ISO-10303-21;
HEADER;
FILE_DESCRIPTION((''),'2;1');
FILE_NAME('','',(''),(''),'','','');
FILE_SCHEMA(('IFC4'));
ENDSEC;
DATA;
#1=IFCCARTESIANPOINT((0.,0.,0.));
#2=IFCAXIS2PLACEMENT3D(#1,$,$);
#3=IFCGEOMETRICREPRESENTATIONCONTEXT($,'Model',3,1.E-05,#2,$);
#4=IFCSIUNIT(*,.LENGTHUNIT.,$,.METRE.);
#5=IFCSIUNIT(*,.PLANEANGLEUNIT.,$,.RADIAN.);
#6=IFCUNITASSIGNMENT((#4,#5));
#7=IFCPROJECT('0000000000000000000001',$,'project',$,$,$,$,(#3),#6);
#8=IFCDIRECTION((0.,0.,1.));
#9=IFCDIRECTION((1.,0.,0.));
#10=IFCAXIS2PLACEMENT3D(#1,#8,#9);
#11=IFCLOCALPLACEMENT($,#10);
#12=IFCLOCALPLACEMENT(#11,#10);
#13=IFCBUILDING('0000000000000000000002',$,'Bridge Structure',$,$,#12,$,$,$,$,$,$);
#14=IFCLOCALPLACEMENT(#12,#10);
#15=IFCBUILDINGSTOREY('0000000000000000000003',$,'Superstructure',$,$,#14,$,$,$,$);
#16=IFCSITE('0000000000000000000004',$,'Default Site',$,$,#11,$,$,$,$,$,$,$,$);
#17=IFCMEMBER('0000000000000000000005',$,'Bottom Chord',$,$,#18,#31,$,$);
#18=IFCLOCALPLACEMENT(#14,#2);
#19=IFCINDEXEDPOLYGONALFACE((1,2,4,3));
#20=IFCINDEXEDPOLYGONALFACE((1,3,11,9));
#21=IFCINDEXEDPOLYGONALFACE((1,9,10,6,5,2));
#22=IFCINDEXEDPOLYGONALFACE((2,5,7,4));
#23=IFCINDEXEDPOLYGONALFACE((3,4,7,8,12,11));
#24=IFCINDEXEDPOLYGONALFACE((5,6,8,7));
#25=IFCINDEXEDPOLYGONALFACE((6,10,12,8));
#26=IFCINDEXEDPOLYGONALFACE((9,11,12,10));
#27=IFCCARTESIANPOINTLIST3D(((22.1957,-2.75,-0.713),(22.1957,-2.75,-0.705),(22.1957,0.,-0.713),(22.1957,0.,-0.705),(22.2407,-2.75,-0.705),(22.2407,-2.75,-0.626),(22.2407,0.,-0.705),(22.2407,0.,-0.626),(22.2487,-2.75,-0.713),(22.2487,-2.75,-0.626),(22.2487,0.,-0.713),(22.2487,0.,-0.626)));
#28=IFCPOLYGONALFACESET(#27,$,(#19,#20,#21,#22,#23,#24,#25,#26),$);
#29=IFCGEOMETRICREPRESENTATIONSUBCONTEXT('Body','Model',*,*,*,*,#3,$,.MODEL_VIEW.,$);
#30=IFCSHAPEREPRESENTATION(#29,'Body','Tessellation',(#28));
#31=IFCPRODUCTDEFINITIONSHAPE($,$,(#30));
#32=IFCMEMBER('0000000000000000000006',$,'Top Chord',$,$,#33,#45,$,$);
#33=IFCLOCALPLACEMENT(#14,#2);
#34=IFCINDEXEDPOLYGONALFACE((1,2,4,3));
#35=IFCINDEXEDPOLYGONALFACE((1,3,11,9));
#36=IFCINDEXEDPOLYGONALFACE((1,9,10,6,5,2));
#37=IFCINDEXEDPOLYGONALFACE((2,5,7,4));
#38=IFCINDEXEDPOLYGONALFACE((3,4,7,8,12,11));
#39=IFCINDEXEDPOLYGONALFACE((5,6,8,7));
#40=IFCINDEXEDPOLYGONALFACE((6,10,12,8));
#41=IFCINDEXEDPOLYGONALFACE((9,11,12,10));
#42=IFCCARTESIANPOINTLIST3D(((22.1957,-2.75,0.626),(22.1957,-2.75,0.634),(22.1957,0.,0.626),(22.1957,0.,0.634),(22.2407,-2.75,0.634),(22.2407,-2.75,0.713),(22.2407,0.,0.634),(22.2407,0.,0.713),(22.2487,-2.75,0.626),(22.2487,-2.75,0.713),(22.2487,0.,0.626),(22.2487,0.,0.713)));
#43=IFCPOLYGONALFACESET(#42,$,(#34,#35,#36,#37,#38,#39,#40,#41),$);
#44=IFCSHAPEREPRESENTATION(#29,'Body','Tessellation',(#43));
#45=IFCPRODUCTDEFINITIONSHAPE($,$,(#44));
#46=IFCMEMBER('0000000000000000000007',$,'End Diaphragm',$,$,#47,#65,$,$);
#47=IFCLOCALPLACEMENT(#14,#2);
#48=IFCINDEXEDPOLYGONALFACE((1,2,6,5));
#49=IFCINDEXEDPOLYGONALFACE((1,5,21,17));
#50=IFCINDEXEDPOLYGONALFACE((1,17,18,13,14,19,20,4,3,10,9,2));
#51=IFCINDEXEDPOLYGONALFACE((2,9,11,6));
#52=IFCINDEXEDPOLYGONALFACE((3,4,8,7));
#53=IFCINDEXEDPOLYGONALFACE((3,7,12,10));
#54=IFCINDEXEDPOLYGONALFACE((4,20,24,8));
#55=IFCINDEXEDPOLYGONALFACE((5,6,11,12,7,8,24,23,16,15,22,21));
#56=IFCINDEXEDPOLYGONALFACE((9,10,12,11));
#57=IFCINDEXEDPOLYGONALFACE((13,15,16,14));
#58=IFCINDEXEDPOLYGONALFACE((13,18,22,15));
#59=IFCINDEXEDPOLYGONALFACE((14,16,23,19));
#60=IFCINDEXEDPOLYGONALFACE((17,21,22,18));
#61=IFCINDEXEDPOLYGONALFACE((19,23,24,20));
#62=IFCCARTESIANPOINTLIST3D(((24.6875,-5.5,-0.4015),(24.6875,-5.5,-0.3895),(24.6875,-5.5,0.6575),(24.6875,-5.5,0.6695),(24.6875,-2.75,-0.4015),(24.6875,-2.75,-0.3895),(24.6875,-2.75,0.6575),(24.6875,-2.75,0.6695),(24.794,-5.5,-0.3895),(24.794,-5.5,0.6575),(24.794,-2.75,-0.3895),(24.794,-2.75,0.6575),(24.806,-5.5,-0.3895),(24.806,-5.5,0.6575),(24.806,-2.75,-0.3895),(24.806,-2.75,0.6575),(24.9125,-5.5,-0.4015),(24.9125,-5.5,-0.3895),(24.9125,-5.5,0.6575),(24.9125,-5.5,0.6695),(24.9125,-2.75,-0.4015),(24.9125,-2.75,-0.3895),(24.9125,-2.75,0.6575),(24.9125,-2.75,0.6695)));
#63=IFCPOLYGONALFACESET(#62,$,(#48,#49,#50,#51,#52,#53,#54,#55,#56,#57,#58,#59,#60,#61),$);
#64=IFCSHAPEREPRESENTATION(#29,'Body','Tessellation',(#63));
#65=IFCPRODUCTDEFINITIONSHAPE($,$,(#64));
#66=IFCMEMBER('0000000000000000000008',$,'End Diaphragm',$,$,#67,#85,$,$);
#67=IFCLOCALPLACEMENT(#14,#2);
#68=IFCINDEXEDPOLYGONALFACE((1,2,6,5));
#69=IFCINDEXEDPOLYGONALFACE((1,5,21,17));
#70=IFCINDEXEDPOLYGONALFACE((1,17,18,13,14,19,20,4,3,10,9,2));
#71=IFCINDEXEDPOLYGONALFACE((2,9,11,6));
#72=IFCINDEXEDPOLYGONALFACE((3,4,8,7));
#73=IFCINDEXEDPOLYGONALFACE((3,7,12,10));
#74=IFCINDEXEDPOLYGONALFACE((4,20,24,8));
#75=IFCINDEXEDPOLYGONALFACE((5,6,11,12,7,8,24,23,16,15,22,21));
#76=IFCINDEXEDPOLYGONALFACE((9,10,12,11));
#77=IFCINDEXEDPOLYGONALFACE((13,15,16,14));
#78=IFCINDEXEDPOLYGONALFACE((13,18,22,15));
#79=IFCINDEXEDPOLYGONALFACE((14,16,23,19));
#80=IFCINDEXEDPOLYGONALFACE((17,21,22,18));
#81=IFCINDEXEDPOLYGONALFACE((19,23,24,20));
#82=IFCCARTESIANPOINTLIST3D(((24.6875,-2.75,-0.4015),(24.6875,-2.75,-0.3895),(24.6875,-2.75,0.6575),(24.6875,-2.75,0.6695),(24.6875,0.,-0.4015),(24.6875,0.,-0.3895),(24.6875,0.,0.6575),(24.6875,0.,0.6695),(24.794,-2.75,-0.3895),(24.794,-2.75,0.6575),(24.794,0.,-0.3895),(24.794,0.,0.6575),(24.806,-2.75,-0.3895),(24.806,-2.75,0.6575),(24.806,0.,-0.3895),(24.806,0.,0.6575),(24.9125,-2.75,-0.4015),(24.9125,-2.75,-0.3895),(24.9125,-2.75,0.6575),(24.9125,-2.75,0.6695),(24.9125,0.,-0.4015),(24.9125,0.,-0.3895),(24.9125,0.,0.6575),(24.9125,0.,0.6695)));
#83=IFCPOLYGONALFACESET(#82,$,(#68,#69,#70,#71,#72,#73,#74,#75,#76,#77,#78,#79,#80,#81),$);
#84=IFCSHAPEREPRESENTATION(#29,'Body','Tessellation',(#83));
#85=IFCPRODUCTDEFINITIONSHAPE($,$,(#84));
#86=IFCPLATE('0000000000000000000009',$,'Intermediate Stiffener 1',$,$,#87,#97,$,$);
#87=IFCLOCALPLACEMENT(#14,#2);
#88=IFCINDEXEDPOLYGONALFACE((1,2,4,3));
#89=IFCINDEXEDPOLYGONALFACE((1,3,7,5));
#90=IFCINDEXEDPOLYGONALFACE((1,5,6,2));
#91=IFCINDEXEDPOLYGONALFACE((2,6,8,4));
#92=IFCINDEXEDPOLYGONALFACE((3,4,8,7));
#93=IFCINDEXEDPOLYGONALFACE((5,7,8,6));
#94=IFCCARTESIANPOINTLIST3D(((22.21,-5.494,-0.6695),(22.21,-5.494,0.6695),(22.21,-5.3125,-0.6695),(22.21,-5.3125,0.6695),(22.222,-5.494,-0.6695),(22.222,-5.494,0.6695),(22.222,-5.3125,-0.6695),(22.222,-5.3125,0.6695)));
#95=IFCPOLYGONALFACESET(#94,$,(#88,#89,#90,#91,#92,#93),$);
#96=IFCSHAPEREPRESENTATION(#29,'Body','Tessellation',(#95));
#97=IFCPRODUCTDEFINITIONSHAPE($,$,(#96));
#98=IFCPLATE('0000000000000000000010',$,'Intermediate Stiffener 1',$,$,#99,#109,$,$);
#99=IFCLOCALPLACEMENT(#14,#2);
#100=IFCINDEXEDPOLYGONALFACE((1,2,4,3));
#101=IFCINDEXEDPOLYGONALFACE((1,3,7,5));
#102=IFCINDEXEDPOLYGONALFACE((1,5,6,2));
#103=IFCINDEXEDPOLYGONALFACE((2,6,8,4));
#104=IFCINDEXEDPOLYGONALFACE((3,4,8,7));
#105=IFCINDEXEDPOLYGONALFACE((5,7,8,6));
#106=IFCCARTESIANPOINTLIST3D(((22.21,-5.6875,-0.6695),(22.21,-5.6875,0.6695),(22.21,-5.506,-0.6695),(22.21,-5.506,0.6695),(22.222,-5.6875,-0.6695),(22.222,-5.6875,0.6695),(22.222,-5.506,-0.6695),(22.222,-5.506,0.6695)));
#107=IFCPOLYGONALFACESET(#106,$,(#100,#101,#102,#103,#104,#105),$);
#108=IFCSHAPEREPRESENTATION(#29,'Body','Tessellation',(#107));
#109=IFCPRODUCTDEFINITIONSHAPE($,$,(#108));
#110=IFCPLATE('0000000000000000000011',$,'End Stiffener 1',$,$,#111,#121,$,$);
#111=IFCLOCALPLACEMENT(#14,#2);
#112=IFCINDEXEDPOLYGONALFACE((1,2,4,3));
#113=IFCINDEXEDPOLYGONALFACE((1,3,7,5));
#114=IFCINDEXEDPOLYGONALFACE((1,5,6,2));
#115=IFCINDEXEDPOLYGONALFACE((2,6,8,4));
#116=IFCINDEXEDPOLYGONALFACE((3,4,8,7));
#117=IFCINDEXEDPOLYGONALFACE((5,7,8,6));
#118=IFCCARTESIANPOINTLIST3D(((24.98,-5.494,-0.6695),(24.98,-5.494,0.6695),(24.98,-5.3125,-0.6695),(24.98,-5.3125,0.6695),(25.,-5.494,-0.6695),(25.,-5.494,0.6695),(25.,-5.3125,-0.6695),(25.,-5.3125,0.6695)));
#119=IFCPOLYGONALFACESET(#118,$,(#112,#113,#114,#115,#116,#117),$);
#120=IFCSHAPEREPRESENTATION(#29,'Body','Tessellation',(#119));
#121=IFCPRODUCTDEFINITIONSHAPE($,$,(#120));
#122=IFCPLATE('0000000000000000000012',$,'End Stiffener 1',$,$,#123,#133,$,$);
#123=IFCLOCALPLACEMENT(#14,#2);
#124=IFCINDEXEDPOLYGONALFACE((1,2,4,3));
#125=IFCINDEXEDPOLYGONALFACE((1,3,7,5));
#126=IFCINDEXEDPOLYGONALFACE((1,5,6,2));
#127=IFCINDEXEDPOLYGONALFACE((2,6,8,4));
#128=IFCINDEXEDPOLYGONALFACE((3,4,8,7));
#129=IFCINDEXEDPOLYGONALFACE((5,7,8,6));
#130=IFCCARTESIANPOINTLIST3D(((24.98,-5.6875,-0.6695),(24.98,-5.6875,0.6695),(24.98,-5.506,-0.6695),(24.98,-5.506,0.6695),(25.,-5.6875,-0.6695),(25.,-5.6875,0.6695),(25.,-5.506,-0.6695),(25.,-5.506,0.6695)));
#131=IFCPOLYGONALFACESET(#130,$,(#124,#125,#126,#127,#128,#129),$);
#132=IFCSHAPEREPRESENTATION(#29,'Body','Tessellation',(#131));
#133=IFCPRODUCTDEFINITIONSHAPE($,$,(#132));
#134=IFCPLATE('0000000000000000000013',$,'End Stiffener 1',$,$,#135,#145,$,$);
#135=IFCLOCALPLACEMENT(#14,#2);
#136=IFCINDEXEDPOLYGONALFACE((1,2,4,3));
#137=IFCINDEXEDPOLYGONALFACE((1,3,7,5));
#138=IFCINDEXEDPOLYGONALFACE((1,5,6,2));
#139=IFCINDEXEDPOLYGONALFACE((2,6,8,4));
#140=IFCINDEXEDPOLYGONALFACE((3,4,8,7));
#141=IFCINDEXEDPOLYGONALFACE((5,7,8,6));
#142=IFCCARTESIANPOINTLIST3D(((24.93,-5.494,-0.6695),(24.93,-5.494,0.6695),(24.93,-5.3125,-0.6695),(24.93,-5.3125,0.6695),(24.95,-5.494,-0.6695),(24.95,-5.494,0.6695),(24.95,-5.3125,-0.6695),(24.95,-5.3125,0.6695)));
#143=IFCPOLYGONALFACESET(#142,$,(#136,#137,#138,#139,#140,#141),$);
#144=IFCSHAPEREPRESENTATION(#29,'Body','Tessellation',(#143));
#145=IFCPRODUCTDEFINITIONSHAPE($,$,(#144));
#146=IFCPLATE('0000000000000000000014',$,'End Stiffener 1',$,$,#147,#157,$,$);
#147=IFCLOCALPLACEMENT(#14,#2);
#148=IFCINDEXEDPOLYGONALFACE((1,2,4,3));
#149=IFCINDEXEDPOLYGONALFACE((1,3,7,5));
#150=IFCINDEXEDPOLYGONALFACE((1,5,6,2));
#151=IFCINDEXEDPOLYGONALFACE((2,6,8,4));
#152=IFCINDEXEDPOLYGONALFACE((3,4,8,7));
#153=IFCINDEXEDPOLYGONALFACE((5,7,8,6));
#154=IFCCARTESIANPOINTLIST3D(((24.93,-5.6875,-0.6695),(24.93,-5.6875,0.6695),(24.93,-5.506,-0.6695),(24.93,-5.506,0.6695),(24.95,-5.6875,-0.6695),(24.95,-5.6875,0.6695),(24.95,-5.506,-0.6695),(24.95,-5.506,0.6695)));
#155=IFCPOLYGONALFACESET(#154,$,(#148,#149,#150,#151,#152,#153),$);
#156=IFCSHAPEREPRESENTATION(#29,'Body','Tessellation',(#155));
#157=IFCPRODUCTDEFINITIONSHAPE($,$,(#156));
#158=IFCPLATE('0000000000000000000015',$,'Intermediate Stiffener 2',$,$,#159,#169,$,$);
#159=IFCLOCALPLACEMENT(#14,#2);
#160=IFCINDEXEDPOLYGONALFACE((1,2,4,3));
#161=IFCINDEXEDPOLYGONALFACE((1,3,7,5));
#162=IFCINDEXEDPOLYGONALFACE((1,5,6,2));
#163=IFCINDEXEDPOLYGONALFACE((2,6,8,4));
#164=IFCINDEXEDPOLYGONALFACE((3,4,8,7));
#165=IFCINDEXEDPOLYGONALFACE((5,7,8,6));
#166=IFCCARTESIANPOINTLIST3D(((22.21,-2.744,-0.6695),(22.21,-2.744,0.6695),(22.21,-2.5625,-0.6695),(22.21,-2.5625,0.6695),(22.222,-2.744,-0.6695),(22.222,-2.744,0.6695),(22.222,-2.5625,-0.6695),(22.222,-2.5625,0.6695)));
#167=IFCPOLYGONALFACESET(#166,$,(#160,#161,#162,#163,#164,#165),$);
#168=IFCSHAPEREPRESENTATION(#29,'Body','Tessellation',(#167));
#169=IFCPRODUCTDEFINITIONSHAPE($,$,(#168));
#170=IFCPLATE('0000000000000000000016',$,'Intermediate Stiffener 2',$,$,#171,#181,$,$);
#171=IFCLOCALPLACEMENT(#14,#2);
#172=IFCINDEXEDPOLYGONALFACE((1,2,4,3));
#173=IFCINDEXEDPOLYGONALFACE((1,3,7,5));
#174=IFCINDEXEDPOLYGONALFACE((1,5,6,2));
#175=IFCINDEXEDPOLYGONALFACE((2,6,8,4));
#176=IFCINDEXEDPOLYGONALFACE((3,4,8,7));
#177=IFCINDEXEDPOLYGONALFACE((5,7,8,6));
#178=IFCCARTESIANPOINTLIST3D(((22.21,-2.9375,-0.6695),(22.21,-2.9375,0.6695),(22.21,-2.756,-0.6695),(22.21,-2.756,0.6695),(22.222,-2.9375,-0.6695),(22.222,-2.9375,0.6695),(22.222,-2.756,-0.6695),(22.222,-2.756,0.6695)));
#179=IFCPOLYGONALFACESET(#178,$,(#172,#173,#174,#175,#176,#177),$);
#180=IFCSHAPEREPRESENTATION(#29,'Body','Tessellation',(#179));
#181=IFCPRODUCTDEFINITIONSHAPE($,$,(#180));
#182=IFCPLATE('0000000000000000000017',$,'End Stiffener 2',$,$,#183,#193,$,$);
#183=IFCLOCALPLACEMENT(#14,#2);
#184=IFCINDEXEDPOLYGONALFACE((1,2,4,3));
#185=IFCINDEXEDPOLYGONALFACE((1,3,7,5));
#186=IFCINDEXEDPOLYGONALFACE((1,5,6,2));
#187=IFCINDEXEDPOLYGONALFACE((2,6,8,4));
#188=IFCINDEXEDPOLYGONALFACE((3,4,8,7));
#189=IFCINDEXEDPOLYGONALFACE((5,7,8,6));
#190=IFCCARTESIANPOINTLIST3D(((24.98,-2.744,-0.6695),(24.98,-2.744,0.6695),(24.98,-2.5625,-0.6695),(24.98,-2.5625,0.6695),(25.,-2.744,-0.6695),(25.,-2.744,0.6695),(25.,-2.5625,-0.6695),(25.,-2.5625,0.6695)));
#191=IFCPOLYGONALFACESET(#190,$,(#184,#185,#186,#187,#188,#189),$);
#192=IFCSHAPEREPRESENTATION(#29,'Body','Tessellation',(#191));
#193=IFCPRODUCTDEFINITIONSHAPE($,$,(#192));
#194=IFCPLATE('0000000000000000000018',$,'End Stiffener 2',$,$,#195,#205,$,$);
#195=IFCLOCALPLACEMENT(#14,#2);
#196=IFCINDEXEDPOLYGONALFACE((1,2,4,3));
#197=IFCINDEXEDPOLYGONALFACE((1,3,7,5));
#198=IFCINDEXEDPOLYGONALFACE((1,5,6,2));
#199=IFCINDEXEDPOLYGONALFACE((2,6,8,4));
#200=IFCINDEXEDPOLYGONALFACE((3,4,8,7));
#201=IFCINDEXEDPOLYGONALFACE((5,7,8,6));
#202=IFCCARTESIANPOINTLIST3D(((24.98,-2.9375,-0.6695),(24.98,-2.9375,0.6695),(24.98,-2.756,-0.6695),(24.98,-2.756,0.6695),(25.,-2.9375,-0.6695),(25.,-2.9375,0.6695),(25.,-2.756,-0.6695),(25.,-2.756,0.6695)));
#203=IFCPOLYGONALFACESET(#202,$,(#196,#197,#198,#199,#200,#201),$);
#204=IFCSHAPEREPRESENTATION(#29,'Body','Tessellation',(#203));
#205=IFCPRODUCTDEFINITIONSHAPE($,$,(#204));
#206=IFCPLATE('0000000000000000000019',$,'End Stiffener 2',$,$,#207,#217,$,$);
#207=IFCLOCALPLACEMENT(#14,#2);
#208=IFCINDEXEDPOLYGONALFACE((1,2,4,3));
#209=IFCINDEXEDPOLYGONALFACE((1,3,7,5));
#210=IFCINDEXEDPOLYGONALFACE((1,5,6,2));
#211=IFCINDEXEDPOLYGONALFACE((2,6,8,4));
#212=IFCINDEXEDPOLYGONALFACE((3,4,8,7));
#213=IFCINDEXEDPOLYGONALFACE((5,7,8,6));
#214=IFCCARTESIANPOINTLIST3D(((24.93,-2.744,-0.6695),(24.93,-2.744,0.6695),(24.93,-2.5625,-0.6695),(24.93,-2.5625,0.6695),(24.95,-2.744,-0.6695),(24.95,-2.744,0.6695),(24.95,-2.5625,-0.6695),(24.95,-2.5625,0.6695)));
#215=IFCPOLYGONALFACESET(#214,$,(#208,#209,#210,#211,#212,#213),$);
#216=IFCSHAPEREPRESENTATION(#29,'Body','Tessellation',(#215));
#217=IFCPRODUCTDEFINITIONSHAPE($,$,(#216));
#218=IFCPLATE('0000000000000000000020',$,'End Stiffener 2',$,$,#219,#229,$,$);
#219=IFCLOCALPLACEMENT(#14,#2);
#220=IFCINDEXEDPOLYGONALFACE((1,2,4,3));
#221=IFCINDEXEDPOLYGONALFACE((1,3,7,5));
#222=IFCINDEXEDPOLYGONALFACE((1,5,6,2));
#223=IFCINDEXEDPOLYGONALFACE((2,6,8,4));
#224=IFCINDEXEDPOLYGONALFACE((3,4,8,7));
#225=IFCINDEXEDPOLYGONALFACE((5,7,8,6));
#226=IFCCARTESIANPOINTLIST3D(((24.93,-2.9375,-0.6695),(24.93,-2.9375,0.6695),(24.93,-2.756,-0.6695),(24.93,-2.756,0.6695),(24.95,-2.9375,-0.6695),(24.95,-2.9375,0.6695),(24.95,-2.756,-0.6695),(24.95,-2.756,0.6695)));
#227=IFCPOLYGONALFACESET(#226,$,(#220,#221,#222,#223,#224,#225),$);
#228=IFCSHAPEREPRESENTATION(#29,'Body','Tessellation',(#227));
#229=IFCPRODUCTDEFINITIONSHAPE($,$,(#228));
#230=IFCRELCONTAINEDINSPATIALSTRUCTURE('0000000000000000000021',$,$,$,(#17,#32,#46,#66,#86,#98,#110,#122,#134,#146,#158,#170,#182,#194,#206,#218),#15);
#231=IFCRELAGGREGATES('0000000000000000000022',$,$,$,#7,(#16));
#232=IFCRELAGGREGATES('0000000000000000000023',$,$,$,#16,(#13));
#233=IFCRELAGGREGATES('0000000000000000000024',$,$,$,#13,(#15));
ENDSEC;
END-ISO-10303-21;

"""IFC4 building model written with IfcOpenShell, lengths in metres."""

from ifc_helpers import new_model, si_unit, frame, origin, origin_with_axes, origin_2d_with_axis, place, context, subcontext, project, spatial, rectangle, i_section, l_section, extrude, element, save


model = new_model("IFC4")

# Units and contexts
model_context = context("Model", 3, precision=1e-05, world=origin())
body_context = subcontext(model_context, "Body", "Model", "MODEL_VIEW")
ifc_project = project(units=[si_unit("LENGTHUNIT", "METRE"), si_unit("PLANEANGLEUNIT", "RADIAN")], contexts=[model_context])

# Site, building, storey
site_placement = place(None, origin_with_axes())
site = spatial("IfcSite", under=ifc_project, at=site_placement, Name="Default Site")
building_placement = place(site_placement, origin_with_axes())
building = spatial("IfcBuilding", under=site, at=building_placement, Name="Bridge Structure")
storey_placement = place(building_placement, origin_with_axes())
storey = spatial("IfcBuildingStorey", under=building, at=storey_placement, Name="Superstructure")

# Members
for number, where, z_axis, x_axis, name in (
    (1, (22.2222, -2.75, -0.6695), (0.0, 1.0, 0.0), (-1.0, 0.0, 0.0), "Bottom Chord"),
    (2, (22.2222, -2.75, 0.6695), (0.0, 1.0, 0.0), (-1.0, 0.0, 0.0), "Top Chord"),
):
    element("IfcMember", number, at=place(storey_placement, frame(where, z_axis=z_axis, x_axis=x_axis)), inside=storey, Name=name, context=body_context, shape_type="SweptSolid", body=[
        extrude(l_section(Depth=0.087, Width=0.053, Thickness=0.008, at=origin_2d_with_axis()), origin_with_axes(), (0.0, 0.0, 1.0), 2.75),
    ])
for number, where, z_axis, x_axis, name in (
    (3, (24.8, -5.5, 0.134), (0.0, 1.0, 0.0), (-1.0, 0.0, 0.0), "End Diaphragm"),
    (4, (24.8, -2.75, 0.134), (0.0, 1.0, 0.0), (-1.0, 0.0, 0.0), "End Diaphragm"),
):
    element("IfcMember", number, at=place(storey_placement, frame(where, z_axis=z_axis, x_axis=x_axis)), inside=storey, Name=name, context=body_context, shape_type="SweptSolid", body=[
        extrude(i_section(OverallWidth=0.225, OverallDepth=1.071, WebThickness=0.012, FlangeThickness=0.012, at=origin_2d_with_axis()), origin_with_axes(), (0.0, 0.0, 1.0), 2.75),
    ])

# Plates
for number, where, z_axis, x_axis, name in (
    (5, (22.216, -5.4032, -0.6695), (0.0, 0.0, 1.0), (1.0, 0.0, 0.0), "Intermediate Stiffener 1"),
    (6, (22.216, -5.5968, -0.6695), (0.0, 0.0, 1.0), (1.0, 0.0, 0.0), "Intermediate Stiffener 1"),
):
    element("IfcPlate", number, at=place(storey_placement, frame(where, z_axis=z_axis, x_axis=x_axis)), inside=storey, Name=name, context=body_context, shape_type="SweptSolid", body=[
        extrude(rectangle(XDim=0.012, YDim=0.1815, at=origin_2d_with_axis()), origin_with_axes(), (0.0, 0.0, 1.0), 1.339),
    ])
for number, where, z_axis, x_axis, name in (
    (7, (24.99, -5.4032, -0.6695), (0.0, 0.0, 1.0), (1.0, 0.0, 0.0), "End Stiffener 1"),
    (8, (24.99, -5.5968, -0.6695), (0.0, 0.0, 1.0), (1.0, 0.0, 0.0), "End Stiffener 1"),
    (9, (24.94, -5.4032, -0.6695), (0.0, 0.0, 1.0), (1.0, 0.0, 0.0), "End Stiffener 1"),
    (10, (24.94, -5.5968, -0.6695), (0.0, 0.0, 1.0), (1.0, 0.0, 0.0), "End Stiffener 1"),
):
    element("IfcPlate", number, at=place(storey_placement, frame(where, z_axis=z_axis, x_axis=x_axis)), inside=storey, Name=name, context=body_context, shape_type="SweptSolid", body=[
        extrude(rectangle(XDim=0.02, YDim=0.1815, at=origin_2d_with_axis()), origin_with_axes(), (0.0, 0.0, 1.0), 1.339),
    ])
for number, where, z_axis, x_axis, name in (
    (11, (22.216, -2.6532, -0.6695), (0.0, 0.0, 1.0), (1.0, 0.0, 0.0), "Intermediate Stiffener 2"),
    (12, (22.216, -2.8468, -0.6695), (0.0, 0.0, 1.0), (1.0, 0.0, 0.0), "Intermediate Stiffener 2"),
):
    element("IfcPlate", number, at=place(storey_placement, frame(where, z_axis=z_axis, x_axis=x_axis)), inside=storey, Name=name, context=body_context, shape_type="SweptSolid", body=[
        extrude(rectangle(XDim=0.012, YDim=0.1815, at=origin_2d_with_axis()), origin_with_axes(), (0.0, 0.0, 1.0), 1.339),
    ])
for number, where, z_axis, x_axis, name in (
    (13, (24.99, -2.6532, -0.6695), (0.0, 0.0, 1.0), (1.0, 0.0, 0.0), "End Stiffener 2"),
    (14, (24.99, -2.8468, -0.6695), (0.0, 0.0, 1.0), (1.0, 0.0, 0.0), "End Stiffener 2"),
    (15, (24.94, -2.6532, -0.6695), (0.0, 0.0, 1.0), (1.0, 0.0, 0.0), "End Stiffener 2"),
    (16, (24.94, -2.8468, -0.6695), (0.0, 0.0, 1.0), (1.0, 0.0, 0.0), "End Stiffener 2"),
):
    element("IfcPlate", number, at=place(storey_placement, frame(where, z_axis=z_axis, x_axis=x_axis)), inside=storey, Name=name, context=body_context, shape_type="SweptSolid", body=[
        extrude(rectangle(XDim=0.02, YDim=0.1815, at=origin_2d_with_axis()), origin_with_axes(), (0.0, 0.0, 1.0), 1.339),
    ])

save(model, "model.ifc")
